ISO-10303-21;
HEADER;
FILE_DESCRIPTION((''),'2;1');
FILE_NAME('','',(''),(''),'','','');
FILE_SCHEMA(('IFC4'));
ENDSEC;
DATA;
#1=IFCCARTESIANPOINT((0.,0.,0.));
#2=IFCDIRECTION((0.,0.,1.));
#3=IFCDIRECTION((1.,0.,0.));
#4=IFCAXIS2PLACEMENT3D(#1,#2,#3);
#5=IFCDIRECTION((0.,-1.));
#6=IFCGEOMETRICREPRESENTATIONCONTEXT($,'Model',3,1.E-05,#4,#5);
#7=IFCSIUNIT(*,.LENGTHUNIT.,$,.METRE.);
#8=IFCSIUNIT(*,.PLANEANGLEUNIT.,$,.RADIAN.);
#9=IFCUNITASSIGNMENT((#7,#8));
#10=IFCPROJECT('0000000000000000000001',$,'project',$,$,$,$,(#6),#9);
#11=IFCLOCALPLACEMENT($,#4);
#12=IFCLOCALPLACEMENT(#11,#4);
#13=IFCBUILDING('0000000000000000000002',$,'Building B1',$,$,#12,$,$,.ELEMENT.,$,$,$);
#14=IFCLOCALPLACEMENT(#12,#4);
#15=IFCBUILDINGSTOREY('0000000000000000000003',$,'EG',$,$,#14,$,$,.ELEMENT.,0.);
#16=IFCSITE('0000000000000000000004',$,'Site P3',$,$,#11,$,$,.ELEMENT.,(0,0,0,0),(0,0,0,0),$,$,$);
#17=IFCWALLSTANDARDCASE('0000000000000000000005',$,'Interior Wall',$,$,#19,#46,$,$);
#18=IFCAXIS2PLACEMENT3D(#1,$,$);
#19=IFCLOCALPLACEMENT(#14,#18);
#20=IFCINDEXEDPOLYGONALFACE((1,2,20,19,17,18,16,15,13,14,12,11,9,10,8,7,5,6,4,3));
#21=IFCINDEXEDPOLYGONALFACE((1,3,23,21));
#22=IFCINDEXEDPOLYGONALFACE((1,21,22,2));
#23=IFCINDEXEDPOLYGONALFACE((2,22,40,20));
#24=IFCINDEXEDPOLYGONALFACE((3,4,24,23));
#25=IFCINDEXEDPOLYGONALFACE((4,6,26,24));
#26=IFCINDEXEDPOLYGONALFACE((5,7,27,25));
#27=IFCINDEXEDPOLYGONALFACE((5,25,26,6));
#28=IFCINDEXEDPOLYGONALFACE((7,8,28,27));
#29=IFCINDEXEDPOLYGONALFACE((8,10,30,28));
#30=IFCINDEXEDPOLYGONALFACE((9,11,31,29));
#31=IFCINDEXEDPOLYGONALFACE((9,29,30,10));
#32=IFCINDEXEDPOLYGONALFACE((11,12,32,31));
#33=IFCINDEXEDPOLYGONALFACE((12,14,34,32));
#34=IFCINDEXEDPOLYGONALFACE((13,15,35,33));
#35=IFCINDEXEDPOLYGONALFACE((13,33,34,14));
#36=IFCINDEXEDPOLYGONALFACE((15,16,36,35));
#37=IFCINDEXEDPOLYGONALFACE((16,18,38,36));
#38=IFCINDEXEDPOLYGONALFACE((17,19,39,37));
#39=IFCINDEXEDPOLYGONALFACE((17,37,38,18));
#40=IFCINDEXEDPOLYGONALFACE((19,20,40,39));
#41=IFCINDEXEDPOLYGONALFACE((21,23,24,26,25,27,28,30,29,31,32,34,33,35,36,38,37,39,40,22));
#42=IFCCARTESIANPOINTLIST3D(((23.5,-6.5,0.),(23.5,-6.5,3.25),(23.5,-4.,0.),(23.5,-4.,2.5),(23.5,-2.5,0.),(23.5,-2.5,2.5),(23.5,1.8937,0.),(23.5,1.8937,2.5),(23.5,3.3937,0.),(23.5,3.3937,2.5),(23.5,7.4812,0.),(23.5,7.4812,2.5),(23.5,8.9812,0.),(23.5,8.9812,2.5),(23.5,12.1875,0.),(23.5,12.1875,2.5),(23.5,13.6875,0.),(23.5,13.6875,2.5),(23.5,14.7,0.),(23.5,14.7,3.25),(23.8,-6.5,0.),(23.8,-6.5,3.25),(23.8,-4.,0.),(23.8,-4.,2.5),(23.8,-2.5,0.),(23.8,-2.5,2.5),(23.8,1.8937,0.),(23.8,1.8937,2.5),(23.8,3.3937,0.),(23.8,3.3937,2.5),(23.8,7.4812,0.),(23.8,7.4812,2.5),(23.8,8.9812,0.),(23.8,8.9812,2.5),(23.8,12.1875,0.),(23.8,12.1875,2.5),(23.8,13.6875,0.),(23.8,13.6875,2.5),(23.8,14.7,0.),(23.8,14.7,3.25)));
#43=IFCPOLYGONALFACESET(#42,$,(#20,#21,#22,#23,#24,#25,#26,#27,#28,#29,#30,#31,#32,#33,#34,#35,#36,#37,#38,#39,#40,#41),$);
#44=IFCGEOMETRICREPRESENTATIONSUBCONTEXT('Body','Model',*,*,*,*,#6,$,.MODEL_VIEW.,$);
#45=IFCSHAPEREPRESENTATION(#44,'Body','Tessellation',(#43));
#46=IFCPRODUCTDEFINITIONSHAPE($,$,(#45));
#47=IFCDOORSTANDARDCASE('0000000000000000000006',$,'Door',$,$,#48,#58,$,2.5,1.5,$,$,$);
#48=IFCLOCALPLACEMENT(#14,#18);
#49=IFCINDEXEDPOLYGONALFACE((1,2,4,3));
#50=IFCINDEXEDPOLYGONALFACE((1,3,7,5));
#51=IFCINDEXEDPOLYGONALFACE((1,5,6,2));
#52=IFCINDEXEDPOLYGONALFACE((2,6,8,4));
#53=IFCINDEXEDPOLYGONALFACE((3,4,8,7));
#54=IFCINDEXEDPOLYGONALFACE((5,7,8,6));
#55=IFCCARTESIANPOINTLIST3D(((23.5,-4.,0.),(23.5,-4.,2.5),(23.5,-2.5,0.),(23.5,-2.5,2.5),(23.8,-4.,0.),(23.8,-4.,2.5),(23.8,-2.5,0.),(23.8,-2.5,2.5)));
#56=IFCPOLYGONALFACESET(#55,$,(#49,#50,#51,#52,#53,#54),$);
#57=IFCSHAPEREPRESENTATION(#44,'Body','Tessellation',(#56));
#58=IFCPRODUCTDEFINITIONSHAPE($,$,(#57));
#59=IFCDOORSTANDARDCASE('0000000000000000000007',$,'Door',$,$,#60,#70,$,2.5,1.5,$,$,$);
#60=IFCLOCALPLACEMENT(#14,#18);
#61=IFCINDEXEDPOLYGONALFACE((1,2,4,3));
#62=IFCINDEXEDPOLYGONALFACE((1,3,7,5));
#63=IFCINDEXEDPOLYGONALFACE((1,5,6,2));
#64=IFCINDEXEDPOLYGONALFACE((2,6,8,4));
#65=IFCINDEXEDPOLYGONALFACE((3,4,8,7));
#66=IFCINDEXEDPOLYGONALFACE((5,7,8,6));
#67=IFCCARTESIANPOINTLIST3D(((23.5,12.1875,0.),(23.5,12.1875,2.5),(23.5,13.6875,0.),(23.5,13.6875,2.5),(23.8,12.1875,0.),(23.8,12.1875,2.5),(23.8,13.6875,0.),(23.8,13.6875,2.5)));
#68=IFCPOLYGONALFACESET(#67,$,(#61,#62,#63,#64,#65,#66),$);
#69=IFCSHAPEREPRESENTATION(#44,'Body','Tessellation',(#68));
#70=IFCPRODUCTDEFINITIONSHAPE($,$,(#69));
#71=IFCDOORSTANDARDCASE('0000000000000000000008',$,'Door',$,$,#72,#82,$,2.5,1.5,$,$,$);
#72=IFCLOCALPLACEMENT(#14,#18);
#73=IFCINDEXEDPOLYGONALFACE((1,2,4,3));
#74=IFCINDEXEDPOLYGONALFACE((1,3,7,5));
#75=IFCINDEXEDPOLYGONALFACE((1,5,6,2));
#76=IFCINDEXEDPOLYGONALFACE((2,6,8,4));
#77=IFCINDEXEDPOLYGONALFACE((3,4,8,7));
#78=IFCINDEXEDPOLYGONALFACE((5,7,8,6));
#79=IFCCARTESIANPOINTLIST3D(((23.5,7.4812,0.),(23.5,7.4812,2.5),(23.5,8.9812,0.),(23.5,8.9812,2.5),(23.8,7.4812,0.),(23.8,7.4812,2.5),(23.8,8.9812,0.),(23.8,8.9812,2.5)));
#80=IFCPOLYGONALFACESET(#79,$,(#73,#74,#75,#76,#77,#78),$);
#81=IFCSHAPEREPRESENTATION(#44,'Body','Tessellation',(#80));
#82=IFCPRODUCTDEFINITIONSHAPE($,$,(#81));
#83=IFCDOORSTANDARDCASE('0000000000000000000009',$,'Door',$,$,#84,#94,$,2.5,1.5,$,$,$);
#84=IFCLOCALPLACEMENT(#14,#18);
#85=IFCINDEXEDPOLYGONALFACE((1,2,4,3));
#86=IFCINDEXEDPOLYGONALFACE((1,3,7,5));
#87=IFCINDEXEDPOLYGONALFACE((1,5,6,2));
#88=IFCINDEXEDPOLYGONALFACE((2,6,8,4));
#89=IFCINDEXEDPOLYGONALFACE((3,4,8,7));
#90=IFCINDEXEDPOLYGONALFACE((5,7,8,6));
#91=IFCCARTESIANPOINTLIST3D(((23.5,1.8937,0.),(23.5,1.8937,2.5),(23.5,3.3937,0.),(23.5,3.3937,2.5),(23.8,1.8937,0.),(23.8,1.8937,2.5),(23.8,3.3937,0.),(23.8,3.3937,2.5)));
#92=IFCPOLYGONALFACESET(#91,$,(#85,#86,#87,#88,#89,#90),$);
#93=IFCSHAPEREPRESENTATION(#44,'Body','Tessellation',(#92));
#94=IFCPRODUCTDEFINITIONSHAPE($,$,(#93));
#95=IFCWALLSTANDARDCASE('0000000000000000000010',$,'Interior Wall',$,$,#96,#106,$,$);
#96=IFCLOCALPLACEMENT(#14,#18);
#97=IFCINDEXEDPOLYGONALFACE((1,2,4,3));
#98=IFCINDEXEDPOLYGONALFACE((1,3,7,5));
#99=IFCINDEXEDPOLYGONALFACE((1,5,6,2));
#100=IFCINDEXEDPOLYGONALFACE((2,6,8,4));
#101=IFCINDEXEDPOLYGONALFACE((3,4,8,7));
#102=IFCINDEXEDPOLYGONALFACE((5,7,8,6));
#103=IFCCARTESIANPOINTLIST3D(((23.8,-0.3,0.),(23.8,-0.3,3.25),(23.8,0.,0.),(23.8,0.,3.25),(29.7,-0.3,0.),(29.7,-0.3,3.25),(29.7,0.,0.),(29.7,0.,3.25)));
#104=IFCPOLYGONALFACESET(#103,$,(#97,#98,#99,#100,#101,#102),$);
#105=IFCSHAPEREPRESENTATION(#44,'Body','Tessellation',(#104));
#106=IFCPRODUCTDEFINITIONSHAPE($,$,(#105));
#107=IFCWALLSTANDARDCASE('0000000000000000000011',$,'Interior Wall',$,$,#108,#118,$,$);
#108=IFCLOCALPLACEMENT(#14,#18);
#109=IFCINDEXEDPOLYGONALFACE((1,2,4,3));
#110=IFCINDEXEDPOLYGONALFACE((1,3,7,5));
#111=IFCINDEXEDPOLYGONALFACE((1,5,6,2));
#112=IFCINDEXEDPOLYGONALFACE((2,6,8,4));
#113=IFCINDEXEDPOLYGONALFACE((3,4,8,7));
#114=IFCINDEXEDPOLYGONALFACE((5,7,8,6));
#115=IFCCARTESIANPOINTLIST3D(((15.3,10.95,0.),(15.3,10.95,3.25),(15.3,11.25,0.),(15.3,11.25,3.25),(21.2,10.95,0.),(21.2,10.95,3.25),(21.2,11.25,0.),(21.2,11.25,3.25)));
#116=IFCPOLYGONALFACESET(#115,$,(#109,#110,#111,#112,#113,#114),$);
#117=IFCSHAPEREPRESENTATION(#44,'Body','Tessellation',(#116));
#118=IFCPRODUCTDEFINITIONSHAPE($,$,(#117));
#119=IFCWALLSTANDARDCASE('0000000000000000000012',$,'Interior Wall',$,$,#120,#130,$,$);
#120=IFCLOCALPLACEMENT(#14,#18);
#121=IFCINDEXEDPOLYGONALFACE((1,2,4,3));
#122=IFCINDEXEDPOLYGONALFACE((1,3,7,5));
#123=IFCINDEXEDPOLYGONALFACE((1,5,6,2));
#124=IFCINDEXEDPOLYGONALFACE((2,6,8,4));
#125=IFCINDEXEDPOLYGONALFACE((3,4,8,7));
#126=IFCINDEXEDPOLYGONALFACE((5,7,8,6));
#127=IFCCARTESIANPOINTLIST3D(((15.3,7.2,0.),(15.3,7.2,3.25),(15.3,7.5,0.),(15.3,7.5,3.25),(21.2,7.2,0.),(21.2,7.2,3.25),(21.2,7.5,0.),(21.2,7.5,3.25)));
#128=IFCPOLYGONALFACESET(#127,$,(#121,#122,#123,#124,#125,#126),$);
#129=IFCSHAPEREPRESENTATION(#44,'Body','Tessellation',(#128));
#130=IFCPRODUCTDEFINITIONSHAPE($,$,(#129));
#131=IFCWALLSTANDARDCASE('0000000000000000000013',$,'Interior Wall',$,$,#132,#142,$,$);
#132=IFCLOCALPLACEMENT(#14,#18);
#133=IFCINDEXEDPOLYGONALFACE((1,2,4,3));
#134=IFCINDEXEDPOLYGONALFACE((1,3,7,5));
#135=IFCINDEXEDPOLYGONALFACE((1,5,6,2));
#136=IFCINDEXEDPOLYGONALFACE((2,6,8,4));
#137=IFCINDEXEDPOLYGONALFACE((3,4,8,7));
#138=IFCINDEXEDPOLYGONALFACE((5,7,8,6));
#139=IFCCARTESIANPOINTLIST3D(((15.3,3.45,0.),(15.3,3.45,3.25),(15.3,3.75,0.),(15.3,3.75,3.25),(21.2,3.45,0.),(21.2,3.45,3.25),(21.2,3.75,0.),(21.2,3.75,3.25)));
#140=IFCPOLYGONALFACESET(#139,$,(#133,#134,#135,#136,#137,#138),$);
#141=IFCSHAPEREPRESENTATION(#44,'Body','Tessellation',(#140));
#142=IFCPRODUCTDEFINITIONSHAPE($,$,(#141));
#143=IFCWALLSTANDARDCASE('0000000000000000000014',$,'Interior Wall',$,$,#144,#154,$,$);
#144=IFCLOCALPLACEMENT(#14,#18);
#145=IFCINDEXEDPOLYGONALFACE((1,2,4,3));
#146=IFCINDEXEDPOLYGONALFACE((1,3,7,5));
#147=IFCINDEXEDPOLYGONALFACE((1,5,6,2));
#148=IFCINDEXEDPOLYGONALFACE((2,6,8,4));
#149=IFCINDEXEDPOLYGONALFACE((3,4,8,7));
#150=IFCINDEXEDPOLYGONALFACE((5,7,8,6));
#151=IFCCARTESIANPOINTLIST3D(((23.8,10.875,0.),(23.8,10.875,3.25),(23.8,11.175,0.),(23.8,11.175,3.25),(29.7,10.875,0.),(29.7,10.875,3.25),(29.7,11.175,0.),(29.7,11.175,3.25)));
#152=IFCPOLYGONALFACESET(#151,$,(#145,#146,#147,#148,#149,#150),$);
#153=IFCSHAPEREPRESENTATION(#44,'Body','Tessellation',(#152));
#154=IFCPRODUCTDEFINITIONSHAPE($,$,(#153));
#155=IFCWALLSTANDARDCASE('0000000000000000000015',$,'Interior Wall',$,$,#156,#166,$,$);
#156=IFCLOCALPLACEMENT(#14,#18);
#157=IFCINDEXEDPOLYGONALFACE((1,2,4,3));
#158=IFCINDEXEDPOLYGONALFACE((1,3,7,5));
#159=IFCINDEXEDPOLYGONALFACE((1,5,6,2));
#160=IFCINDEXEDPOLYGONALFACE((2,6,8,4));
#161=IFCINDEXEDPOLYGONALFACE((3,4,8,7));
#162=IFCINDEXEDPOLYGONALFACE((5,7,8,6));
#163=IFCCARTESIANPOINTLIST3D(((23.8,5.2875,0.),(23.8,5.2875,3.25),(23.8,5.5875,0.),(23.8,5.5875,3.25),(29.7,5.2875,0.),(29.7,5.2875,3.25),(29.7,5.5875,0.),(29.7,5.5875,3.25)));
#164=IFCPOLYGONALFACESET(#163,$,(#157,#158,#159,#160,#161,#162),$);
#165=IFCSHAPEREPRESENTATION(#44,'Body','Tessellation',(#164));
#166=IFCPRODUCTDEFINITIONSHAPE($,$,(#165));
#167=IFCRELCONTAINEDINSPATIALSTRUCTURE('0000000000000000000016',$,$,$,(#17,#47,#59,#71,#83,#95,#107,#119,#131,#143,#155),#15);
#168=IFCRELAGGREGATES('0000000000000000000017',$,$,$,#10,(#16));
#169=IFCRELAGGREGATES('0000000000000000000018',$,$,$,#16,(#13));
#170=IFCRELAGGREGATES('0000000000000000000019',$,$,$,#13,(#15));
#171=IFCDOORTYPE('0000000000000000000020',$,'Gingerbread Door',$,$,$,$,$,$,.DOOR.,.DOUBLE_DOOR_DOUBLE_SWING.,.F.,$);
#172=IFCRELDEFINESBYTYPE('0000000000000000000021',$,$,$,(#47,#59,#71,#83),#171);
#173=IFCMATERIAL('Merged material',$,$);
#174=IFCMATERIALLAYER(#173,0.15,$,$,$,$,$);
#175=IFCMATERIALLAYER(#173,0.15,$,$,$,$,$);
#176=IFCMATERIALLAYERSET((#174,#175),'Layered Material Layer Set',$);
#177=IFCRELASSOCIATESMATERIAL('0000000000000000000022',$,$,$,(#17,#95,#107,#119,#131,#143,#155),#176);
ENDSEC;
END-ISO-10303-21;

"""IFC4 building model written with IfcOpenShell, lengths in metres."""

from ifc_helpers import new_model, si_unit, direction, frame, origin_with_axes, place, context, subcontext, project, spatial, polyline, outline, extrude, source, transform, mapped, material, layer, layer_set, layer_usage, type_object, element, fill, save


model = new_model("IFC4")

# Units and contexts
model_context = context("Model", 3, precision=1e-05, world=origin_with_axes(), true_north=direction((0.0, -1.0)))
body_context = subcontext(model_context, "Body", "Model", "MODEL_VIEW")
ifc_project = project(units=[si_unit("LENGTHUNIT", "METRE"), si_unit("PLANEANGLEUNIT", "RADIAN")], contexts=[model_context])

# Site, building, storey
site_placement = place(None, origin_with_axes())
site = spatial("IfcSite", under=ifc_project, at=site_placement, Name="Site P3", CompositionType="ELEMENT", RefLatitude=(0, 0, 0, 0), RefLongitude=(0, 0, 0, 0))
building_placement = place(site_placement, origin_with_axes())
building = spatial("IfcBuilding", under=site, at=building_placement, Name="Building B1", CompositionType="ELEMENT")
storey_placement = place(building_placement, origin_with_axes())
storey = spatial("IfcBuildingStorey", under=building, at=storey_placement, Name="EG", CompositionType="ELEMENT", Elevation=0.0)

# Shared definitions
ifc_material = material(Name="Merged material")

# Wall, openings, doors
ifc_layer_1 = layer(ifc_material, 0.15)
ifc_layer_2 = layer(ifc_material, 0.15)
ifc_layer_set_1 = layer_set([ifc_layer_1, ifc_layer_2], Name="Layered Material Layer Set")
ifc_layer_usage_1 = layer_usage(ifc_layer_set_1, "AXIS2", "POSITIVE", -0.15)
door_type = type_object("IfcDoorType", Name="Gingerbread Door", OperationType="DOUBLE_DOOR_DOUBLE_SWING", ParameterTakesPrecedence=False, PredefinedType="DOOR")
shared_shape_1 = source(origin_with_axes(), body_context, "Body", "SweptSolid", [
    extrude(outline(polyline([(0.0, 0.0), (0.0, 1.5), (2.5, 1.5), (2.5, 0.0), (0.0, 0.0)])), frame((0.0, -0.15, 0.0), z_axis=(0.0, 1.0, 0.0), x_axis=(0.0, 0.0, 1.0)), (0.0, 0.0, 1.0), 0.3),
])
wall_1_placement = place(storey_placement, frame((23.65, 14.7, 0.0), z_axis=(0.0, 0.0, 1.0), x_axis=(0.0, -1.0, 0.0)))
wall_1 = element("IfcWallStandardCase", 1, at=wall_1_placement, inside=storey, material=ifc_layer_usage_1, Name="Interior Wall", context=body_context, shape_type="SweptSolid", body=[
    extrude(outline(polyline([(0.0, 0.15), (21.2, 0.15), (21.2, -0.15), (0.0, -0.15), (0.0, 0.15)])), origin_with_axes(), (0.0, 0.0, 1.0), 3.25),
])
opening_1_placement = place(wall_1_placement, frame((17.2, 0.0, 0.0), z_axis=(0.0, 0.0, 1.0), x_axis=(1.0, 0.0, 0.0)))
opening_1 = element("IfcOpeningStandardCase", 2, at=opening_1_placement, cuts=wall_1, context=body_context, shape_type="SweptSolid", body=[
    extrude(outline(polyline([(0.0, 0.0), (0.0, 1.5), (2.5, 1.5), (2.5, 0.0), (0.0, 0.0)])), frame((0.0, -0.15, 0.0), z_axis=(0.0, 1.0, 0.0), x_axis=(0.0, 0.0, 1.0)), (0.0, 0.0, 1.0), 0.3),
])
opening_2_placement = place(wall_1_placement, frame((1.0125, 0.0, 0.0), z_axis=(0.0, 0.0, 1.0), x_axis=(1.0, 0.0, 0.0)))
opening_2 = element("IfcOpeningStandardCase", 3, at=opening_2_placement, cuts=wall_1, context=body_context, shape_type="SweptSolid", body=[
    extrude(outline(polyline([(0.0, 0.0), (0.0, 1.5), (2.5, 1.5), (2.5, 0.0), (0.0, 0.0)])), frame((0.0, -0.15, 0.0), z_axis=(0.0, 1.0, 0.0), x_axis=(0.0, 0.0, 1.0)), (0.0, 0.0, 1.0), 0.3),
])
opening_3_placement = place(wall_1_placement, frame((5.7188, 0.0, 0.0), z_axis=(0.0, 0.0, 1.0), x_axis=(1.0, 0.0, 0.0)))
opening_3 = element("IfcOpeningStandardCase", 4, at=opening_3_placement, cuts=wall_1, context=body_context, shape_type="SweptSolid", body=[
    extrude(outline(polyline([(0.0, 0.0), (0.0, 1.5), (2.5, 1.5), (2.5, 0.0), (0.0, 0.0)])), frame((0.0, -0.15, 0.0), z_axis=(0.0, 1.0, 0.0), x_axis=(0.0, 0.0, 1.0)), (0.0, 0.0, 1.0), 0.3),
])
opening_4_placement = place(wall_1_placement, frame((11.3063, 0.0, 0.0), z_axis=(0.0, 0.0, 1.0), x_axis=(1.0, 0.0, 0.0)))
opening_4 = element("IfcOpeningStandardCase", 5, at=opening_4_placement, cuts=wall_1, context=body_context, shape_type="SweptSolid", body=[
    extrude(outline(polyline([(0.0, 0.0), (0.0, 1.5), (2.5, 1.5), (2.5, 0.0), (0.0, 0.0)])), frame((0.0, -0.15, 0.0), z_axis=(0.0, 1.0, 0.0), x_axis=(0.0, 0.0, 1.0)), (0.0, 0.0, 1.0), 0.3),
])
door_1_placement = place(opening_1_placement, origin_with_axes())
door_1 = element("IfcDoorStandardCase", 6, at=door_1_placement, inside=storey, type_object=door_type, Name="Door", OverallHeight=2.5, OverallWidth=1.5, context=body_context, shape_type="MappedRepresentation", body=[
    mapped(shared_shape_1, transform((0.0, 0.0, 0.0))),
])
fill(opening_1, door_1)
door_2_placement = place(opening_2_placement, origin_with_axes())
door_2 = element("IfcDoorStandardCase", 7, at=door_2_placement, inside=storey, type_object=door_type, Name="Door", OverallHeight=2.5, OverallWidth=1.5, context=body_context, shape_type="MappedRepresentation", body=[
    mapped(shared_shape_1, transform((0.0, 0.0, 0.0))),
])
fill(opening_2, door_2)
door_3_placement = place(opening_3_placement, origin_with_axes())
door_3 = element("IfcDoorStandardCase", 8, at=door_3_placement, inside=storey, type_object=door_type, Name="Door", OverallHeight=2.5, OverallWidth=1.5, context=body_context, shape_type="MappedRepresentation", body=[
    mapped(shared_shape_1, transform((0.0, 0.0, 0.0))),
])
fill(opening_3, door_3)
door_4_placement = place(opening_4_placement, origin_with_axes())
door_4 = element("IfcDoorStandardCase", 9, at=door_4_placement, inside=storey, type_object=door_type, Name="Door", OverallHeight=2.5, OverallWidth=1.5, context=body_context, shape_type="MappedRepresentation", body=[
    mapped(shared_shape_1, transform((0.0, 0.0, 0.0))),
])
fill(opening_4, door_4)

# Walls
for number, where, z_axis, x_axis, name in (
    (10, (23.8, -0.15, 0.0), (0.0, 0.0, 1.0), (1.0, 0.0, 0.0), "Interior Wall"),
    (11, (15.3, 11.1, 0.0), (0.0, 0.0, 1.0), (1.0, 0.0, 0.0), "Interior Wall"),
    (12, (15.3, 7.35, 0.0), (0.0, 0.0, 1.0), (1.0, 0.0, 0.0), "Interior Wall"),
    (13, (15.3, 3.6, 0.0), (0.0, 0.0, 1.0), (1.0, 0.0, 0.0), "Interior Wall"),
    (14, (23.8, 11.025, 0.0), (0.0, 0.0, 1.0), (1.0, 0.0, 0.0), "Interior Wall"),
    (15, (23.8, 5.4375, 0.0), (0.0, 0.0, 1.0), (1.0, 0.0, 0.0), "Interior Wall"),
):
    element("IfcWallStandardCase", number, at=place(storey_placement, frame(where, z_axis=z_axis, x_axis=x_axis)), inside=storey, material=ifc_layer_usage_1, Name=name, context=body_context, shape_type="SweptSolid", body=[
        extrude(outline(polyline([(0.0, 0.15), (5.9, 0.15), (5.9, -0.15), (0.0, -0.15), (0.0, 0.15)])), origin_with_axes(), (0.0, 0.0, 1.0), 3.25),
    ])

save(model, "model.ifc")
